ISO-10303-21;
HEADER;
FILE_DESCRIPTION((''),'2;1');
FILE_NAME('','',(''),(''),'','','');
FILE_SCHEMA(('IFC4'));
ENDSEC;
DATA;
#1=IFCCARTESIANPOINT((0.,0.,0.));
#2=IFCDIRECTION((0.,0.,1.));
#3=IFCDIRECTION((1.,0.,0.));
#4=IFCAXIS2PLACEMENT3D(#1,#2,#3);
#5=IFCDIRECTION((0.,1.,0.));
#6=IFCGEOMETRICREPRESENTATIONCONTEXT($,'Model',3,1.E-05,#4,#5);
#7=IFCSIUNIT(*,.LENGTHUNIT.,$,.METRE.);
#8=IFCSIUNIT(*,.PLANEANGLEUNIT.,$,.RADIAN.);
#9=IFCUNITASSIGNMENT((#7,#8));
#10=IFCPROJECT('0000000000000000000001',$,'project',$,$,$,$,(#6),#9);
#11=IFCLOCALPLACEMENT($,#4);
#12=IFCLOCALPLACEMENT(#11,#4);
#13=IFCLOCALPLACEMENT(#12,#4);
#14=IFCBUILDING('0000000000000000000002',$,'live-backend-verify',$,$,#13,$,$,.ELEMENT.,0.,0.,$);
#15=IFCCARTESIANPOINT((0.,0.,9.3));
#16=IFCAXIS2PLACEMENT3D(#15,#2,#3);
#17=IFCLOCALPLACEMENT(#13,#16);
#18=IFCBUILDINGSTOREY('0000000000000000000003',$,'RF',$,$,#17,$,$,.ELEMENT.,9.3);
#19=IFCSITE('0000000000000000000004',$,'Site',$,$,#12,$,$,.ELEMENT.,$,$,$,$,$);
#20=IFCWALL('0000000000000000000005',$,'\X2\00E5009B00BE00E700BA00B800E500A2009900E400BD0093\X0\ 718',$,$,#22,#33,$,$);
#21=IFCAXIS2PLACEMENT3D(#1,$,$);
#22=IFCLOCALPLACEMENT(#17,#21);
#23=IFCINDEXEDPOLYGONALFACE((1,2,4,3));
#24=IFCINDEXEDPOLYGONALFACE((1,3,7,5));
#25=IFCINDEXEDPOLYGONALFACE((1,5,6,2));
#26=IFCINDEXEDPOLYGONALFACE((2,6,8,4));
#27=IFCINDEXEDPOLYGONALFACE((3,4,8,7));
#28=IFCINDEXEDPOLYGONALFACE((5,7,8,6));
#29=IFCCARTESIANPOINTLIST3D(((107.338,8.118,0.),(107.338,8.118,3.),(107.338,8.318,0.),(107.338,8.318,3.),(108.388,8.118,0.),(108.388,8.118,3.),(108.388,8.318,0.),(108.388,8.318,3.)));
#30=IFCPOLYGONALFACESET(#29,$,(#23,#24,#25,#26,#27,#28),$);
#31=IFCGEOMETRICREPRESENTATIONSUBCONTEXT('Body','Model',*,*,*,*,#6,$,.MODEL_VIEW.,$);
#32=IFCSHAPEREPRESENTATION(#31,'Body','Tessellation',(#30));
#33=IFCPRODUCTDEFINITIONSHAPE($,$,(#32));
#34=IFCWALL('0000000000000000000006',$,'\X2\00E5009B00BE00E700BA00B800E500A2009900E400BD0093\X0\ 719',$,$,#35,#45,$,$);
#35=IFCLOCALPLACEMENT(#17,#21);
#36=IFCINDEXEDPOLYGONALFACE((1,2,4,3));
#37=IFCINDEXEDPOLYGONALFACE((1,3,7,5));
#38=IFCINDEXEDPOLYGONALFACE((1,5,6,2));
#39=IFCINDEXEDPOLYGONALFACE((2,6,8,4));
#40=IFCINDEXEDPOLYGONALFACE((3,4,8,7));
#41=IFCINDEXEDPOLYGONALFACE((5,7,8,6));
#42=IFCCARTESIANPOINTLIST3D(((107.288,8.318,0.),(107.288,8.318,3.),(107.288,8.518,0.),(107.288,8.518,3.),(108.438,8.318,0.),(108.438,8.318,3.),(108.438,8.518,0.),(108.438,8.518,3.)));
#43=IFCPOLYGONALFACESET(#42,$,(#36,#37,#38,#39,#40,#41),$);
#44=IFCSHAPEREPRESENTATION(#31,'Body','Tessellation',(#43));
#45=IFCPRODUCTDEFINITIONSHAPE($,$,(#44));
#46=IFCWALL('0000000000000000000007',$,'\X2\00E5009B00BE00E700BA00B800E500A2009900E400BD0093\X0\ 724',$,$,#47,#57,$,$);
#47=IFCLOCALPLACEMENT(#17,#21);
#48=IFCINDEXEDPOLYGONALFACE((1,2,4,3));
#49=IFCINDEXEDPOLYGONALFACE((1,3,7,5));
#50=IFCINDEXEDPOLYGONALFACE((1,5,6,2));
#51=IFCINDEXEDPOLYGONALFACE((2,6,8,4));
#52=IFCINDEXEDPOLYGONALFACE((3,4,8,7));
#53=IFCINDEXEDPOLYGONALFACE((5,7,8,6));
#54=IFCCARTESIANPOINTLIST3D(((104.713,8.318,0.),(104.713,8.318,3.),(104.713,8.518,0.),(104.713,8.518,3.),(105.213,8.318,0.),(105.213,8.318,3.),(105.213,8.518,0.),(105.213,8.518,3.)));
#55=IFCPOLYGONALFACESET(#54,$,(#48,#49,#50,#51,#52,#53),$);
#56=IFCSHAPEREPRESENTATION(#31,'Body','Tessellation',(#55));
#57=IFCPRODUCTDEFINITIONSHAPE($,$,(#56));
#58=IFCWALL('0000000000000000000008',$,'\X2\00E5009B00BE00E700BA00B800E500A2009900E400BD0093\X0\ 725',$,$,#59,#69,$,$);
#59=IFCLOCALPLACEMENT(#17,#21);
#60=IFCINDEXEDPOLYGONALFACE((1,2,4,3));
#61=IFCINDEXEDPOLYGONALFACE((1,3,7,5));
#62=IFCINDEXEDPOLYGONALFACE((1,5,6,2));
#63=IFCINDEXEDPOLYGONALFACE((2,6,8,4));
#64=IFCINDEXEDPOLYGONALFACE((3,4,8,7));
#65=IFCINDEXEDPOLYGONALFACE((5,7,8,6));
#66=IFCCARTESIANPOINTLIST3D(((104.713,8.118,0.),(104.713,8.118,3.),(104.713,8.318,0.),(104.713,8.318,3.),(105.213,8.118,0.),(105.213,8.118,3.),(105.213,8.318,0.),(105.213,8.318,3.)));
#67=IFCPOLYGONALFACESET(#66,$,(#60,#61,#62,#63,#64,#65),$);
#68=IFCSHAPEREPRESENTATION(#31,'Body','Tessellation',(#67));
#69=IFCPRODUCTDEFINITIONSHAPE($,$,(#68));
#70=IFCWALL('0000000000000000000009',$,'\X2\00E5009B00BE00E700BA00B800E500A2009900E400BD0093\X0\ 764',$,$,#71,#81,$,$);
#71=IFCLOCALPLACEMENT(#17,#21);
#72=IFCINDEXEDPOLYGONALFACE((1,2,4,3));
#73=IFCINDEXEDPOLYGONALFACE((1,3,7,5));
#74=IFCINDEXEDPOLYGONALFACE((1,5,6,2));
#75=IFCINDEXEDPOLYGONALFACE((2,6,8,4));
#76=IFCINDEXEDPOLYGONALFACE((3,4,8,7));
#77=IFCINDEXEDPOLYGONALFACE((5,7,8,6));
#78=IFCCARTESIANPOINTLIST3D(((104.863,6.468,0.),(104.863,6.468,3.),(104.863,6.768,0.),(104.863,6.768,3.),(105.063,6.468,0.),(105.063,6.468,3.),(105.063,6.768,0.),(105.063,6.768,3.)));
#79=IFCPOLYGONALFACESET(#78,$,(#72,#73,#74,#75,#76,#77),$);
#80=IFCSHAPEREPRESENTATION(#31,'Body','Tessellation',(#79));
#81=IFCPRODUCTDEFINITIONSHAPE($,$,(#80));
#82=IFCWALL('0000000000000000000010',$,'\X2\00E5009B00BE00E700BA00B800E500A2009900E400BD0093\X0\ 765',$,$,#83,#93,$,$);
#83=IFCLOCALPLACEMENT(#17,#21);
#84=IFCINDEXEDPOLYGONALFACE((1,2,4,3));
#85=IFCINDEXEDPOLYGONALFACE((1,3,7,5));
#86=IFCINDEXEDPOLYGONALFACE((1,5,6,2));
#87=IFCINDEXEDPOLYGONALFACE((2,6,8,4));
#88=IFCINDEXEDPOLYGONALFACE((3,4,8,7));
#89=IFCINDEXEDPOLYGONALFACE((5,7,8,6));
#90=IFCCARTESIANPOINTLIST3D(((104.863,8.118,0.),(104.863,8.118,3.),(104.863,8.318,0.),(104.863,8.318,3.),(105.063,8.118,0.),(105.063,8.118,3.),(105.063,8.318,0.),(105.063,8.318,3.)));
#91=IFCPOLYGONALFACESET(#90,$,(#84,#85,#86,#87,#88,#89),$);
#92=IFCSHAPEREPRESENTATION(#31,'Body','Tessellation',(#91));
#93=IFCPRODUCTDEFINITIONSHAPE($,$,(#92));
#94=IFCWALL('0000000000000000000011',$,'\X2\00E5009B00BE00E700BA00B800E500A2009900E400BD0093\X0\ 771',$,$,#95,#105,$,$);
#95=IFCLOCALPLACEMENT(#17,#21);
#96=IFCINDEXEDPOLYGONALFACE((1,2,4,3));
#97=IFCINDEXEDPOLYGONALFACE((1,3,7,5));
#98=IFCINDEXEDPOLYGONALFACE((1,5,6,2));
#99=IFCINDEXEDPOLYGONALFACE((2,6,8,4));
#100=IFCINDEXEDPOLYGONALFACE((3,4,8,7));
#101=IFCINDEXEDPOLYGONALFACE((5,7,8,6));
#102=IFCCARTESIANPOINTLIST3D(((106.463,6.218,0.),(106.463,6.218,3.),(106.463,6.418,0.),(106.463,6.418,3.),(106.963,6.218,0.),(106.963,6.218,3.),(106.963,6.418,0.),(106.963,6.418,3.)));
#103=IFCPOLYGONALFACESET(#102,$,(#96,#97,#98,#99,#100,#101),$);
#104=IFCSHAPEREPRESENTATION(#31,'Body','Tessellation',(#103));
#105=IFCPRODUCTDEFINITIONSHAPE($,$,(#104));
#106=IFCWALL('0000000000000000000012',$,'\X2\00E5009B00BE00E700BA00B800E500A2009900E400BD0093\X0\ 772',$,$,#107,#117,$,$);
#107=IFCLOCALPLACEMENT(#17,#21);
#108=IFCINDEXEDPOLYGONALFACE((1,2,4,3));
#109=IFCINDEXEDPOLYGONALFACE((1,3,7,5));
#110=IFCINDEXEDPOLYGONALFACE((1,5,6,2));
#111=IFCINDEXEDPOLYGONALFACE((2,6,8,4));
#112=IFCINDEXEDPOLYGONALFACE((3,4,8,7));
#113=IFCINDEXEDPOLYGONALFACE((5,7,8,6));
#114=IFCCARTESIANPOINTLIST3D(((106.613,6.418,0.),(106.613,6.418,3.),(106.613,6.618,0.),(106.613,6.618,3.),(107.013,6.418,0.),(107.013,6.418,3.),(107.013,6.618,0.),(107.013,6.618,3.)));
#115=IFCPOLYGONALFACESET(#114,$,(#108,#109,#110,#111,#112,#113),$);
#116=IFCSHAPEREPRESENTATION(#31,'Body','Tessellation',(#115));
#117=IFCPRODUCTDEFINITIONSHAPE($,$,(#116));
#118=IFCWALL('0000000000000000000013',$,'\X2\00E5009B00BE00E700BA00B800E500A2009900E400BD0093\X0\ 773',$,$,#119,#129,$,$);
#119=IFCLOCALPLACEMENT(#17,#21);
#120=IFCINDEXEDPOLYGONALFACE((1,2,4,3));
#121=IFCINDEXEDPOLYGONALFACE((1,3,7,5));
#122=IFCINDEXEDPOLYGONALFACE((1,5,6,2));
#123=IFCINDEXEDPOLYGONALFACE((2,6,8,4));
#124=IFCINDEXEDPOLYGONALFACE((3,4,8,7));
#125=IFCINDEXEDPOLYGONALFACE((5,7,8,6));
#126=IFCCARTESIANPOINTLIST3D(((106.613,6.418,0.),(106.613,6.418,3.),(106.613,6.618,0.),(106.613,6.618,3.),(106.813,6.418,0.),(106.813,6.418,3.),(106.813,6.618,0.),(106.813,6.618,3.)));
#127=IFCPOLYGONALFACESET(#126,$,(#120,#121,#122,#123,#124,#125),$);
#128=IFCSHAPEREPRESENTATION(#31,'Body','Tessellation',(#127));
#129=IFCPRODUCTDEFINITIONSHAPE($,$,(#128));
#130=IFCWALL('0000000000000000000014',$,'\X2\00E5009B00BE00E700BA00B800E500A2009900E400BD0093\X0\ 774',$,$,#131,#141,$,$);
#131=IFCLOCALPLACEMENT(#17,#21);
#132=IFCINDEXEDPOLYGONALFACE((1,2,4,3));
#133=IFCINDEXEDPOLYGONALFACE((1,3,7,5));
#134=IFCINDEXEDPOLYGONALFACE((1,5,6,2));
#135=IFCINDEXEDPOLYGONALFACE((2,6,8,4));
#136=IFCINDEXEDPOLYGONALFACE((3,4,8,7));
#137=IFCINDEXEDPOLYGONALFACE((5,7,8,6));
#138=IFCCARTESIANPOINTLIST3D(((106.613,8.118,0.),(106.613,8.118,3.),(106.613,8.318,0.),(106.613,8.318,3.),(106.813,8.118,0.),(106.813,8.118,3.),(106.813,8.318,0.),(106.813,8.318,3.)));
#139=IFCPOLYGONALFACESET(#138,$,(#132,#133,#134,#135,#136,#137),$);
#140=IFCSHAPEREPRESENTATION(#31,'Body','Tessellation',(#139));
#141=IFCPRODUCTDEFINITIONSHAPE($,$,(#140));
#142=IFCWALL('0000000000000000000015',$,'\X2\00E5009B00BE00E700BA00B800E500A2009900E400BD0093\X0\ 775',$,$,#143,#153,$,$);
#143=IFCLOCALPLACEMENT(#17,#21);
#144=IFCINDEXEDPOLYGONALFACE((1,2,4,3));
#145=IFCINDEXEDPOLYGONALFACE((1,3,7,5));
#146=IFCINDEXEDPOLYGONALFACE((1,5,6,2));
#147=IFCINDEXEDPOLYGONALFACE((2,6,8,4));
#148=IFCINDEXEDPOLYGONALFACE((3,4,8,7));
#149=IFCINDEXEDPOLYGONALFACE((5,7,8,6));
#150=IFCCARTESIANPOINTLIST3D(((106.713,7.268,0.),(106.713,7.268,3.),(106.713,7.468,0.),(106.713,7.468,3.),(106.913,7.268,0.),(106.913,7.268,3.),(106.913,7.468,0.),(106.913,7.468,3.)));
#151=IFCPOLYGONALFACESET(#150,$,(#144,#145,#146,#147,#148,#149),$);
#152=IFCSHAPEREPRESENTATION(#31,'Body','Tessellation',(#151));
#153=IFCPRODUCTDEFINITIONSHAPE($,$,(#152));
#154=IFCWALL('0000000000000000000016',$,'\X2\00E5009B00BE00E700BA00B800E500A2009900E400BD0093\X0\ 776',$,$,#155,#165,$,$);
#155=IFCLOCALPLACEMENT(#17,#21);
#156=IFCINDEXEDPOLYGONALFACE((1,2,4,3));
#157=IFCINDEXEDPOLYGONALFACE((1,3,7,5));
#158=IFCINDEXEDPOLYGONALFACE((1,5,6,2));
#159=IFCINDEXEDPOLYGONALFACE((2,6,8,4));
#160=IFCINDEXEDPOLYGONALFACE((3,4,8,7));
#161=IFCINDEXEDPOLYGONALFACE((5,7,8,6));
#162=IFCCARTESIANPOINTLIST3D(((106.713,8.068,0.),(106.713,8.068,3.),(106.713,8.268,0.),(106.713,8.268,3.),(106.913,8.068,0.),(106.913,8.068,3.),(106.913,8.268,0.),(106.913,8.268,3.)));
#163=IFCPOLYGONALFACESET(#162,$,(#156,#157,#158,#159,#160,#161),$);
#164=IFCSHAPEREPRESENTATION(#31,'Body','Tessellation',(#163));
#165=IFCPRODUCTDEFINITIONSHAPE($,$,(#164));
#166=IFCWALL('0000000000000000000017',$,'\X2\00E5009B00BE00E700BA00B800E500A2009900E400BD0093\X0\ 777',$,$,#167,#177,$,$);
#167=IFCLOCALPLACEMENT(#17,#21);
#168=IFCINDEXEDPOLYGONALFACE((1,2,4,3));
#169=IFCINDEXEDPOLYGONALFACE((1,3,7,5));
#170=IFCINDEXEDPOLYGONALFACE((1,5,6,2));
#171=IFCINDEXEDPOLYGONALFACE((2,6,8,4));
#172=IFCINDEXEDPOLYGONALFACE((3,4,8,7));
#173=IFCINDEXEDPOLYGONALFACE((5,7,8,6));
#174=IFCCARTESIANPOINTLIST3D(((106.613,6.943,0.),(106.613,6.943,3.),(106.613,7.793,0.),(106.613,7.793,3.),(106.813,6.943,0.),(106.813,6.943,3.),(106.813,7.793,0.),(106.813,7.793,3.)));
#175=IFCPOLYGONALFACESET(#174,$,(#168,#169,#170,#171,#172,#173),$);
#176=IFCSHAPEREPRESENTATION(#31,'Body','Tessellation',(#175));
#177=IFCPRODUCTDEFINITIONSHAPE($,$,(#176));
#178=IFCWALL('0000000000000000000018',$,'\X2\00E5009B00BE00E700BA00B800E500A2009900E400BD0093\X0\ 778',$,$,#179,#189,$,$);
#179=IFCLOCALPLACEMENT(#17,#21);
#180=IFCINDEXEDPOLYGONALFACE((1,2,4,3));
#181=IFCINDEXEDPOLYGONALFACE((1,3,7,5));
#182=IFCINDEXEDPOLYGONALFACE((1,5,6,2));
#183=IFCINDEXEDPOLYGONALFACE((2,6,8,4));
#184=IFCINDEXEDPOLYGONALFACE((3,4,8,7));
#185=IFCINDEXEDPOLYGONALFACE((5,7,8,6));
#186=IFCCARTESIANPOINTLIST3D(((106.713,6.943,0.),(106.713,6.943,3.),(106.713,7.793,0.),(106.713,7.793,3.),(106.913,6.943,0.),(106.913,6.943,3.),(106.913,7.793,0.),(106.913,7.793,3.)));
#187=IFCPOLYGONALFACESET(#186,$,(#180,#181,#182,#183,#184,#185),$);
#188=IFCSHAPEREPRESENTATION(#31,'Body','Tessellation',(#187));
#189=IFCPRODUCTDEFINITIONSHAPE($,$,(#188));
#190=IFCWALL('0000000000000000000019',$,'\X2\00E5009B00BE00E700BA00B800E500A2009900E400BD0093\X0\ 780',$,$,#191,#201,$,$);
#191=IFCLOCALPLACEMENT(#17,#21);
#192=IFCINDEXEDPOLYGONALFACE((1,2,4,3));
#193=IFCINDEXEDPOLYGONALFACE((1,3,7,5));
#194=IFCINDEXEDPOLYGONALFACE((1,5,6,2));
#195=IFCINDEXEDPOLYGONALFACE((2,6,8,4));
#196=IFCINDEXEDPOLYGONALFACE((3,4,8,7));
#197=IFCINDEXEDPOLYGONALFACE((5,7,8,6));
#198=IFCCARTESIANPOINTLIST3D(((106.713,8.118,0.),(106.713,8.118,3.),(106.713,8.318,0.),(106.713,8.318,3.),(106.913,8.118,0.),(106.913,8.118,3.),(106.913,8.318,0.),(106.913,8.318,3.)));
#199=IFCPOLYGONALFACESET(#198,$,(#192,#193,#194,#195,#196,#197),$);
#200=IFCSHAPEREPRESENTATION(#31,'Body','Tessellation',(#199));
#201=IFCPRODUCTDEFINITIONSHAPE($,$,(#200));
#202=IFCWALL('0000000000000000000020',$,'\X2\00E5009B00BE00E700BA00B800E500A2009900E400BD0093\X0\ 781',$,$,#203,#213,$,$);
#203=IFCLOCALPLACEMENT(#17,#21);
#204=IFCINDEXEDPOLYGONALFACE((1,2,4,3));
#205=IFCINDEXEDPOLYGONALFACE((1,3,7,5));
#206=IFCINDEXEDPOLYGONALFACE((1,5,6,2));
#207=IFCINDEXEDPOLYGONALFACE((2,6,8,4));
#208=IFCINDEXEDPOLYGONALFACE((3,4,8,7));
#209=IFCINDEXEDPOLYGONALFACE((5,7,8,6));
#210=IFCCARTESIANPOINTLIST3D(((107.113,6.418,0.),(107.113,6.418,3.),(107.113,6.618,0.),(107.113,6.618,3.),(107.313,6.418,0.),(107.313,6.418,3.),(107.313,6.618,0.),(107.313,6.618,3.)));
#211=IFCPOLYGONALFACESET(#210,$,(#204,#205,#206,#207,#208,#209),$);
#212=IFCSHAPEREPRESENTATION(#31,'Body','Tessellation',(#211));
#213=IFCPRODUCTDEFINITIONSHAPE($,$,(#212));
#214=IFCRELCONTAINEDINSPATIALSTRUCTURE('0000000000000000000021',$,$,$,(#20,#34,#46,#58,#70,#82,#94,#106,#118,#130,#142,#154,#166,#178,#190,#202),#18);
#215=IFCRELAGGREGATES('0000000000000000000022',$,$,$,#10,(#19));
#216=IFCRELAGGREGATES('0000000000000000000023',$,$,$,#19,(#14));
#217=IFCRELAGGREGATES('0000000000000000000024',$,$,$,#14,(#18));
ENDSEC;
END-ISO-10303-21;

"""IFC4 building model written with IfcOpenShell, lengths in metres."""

from ifc_helpers import new_model, si_unit, direction, frame, frame_2d, origin_with_axes, place, context, subcontext, project, spatial, rectangle, extrude, element, save


model = new_model("IFC4")

# Units and contexts
model_context = context("Model", 3, precision=1e-05, world=origin_with_axes(), true_north=direction((0.0, 1.0, 0.0)))
body_context = subcontext(model_context, "Body", "Model", "MODEL_VIEW")
ifc_project = project(units=[si_unit("LENGTHUNIT", "METRE"), si_unit("PLANEANGLEUNIT", "RADIAN")], contexts=[model_context])

# Site, building, storey
placement = place(None, origin_with_axes())
site_placement = place(placement, origin_with_axes())
site = spatial("IfcSite", under=ifc_project, at=site_placement, Name="Site", CompositionType="ELEMENT")
building_placement = place(site_placement, origin_with_axes())
building = spatial("IfcBuilding", under=site, at=building_placement, Name="live-backend-verify", CompositionType="ELEMENT", ElevationOfRefHeight=0.0, ElevationOfTerrain=0.0)
storey_placement = place(building_placement, frame((0.0, 0.0, 9.3), z_axis=(0.0, 0.0, 1.0), x_axis=(1.0, 0.0, 0.0)))
storey = spatial("IfcBuildingStorey", under=building, at=storey_placement, Name="RF", CompositionType="ELEMENT", Elevation=9.3)

# Walls
wall_1_placement = place(storey_placement, frame((107.863, 8.218, 0.0), z_axis=(0.0, 0.0, 1.0), x_axis=(-1.0, 0.0, 0.0)))
element("IfcWall", 1, at=wall_1_placement, inside=storey, Name="å\u009b¾çº¸å¢\u0099ä½\u0093 718", context=body_context, shape_type="SweptSolid", body=[
    extrude(rectangle(XDim=1.05, YDim=0.2, at=frame_2d((0.0, 0.0), x_axis=(1.0, 0.0, 0.0))), frame((0.0, 0.0, 0.0), z_axis=(0.0, 0.0, 1.0)), (0.0, 0.0, 1.0), 3.0),
])
wall_2_placement = place(storey_placement, frame((107.863, 8.418, 0.0), z_axis=(0.0, 0.0, 1.0), x_axis=(-1.0, 0.0, 0.0)))
element("IfcWall", 2, at=wall_2_placement, inside=storey, Name="å\u009b¾çº¸å¢\u0099ä½\u0093 719", context=body_context, shape_type="SweptSolid", body=[
    extrude(rectangle(XDim=1.15, YDim=0.2, at=frame_2d((0.0, 0.0), x_axis=(1.0, 0.0, 0.0))), frame((0.0, 0.0, 0.0), z_axis=(0.0, 0.0, 1.0)), (0.0, 0.0, 1.0), 3.0),
])
for number, where, z_axis, x_axis, name in (
    (3, (104.963, 8.418, 0.0), (0.0, 0.0, 1.0), (-1.0, 0.0, 0.0), "å\u009b¾çº¸å¢\u0099ä½\u0093 724"),
    (4, (104.963, 8.218, 0.0), (0.0, 0.0, 1.0), (-1.0, 0.0, 0.0), "å\u009b¾çº¸å¢\u0099ä½\u0093 725"),
):
    element("IfcWall", number, at=place(storey_placement, frame(where, z_axis=z_axis, x_axis=x_axis)), inside=storey, Name=name, context=body_context, shape_type="SweptSolid", body=[
        extrude(rectangle(XDim=0.5, YDim=0.2, at=frame_2d((0.0, 0.0), x_axis=(1.0, 0.0, 0.0))), frame((0.0, 0.0, 0.0), z_axis=(0.0, 0.0, 1.0)), (0.0, 0.0, 1.0), 3.0),
    ])
wall_3_placement = place(storey_placement, frame((104.963, 6.618, 0.0), z_axis=(0.0, 0.0, 1.0), x_axis=(0.0, -1.0, 0.0)))
element("IfcWall", 5, at=wall_3_placement, inside=storey, Name="å\u009b¾çº¸å¢\u0099ä½\u0093 764", context=body_context, shape_type="SweptSolid", body=[
    extrude(rectangle(XDim=0.3, YDim=0.2, at=frame_2d((0.0, 0.0), x_axis=(1.0, 0.0, 0.0))), frame((0.0, 0.0, 0.0), z_axis=(0.0, 0.0, 1.0)), (0.0, 0.0, 1.0), 3.0),
])
wall_4_placement = place(storey_placement, frame((104.963, 8.218, 0.0), z_axis=(0.0, 0.0, 1.0), x_axis=(0.0, 1.0, 0.0)))
element("IfcWall", 6, at=wall_4_placement, inside=storey, Name="å\u009b¾çº¸å¢\u0099ä½\u0093 765", context=body_context, shape_type="SweptSolid", body=[
    extrude(rectangle(XDim=0.2, YDim=0.2, at=frame_2d((0.0, 0.0), x_axis=(1.0, 0.0, 0.0))), frame((0.0, 0.0, 0.0), z_axis=(0.0, 0.0, 1.0)), (0.0, 0.0, 1.0), 3.0),
])
wall_5_placement = place(storey_placement, frame((106.713, 6.318, 0.0), z_axis=(0.0, 0.0, 1.0), x_axis=(1.0, 0.0, 0.0)))
element("IfcWall", 7, at=wall_5_placement, inside=storey, Name="å\u009b¾çº¸å¢\u0099ä½\u0093 771", context=body_context, shape_type="SweptSolid", body=[
    extrude(rectangle(XDim=0.5, YDim=0.2, at=frame_2d((0.0, 0.0), x_axis=(1.0, 0.0, 0.0))), frame((0.0, 0.0, 0.0), z_axis=(0.0, 0.0, 1.0)), (0.0, 0.0, 1.0), 3.0),
])
wall_6_placement = place(storey_placement, frame((106.813, 6.518, 0.0), z_axis=(0.0, 0.0, 1.0), x_axis=(1.0, 0.0, 0.0)))
element("IfcWall", 8, at=wall_6_placement, inside=storey, Name="å\u009b¾çº¸å¢\u0099ä½\u0093 772", context=body_context, shape_type="SweptSolid", body=[
    extrude(rectangle(XDim=0.4, YDim=0.2, at=frame_2d((0.0, 0.0), x_axis=(1.0, 0.0, 0.0))), frame((0.0, 0.0, 0.0), z_axis=(0.0, 0.0, 1.0)), (0.0, 0.0, 1.0), 3.0),
])
for number, where, z_axis, x_axis, name in (
    (9, (106.713, 6.518, 0.0), (0.0, 0.0, 1.0), (0.0, -1.0, 0.0), "å\u009b¾çº¸å¢\u0099ä½\u0093 773"),
    (10, (106.713, 8.218, 0.0), (0.0, 0.0, 1.0), (0.0, 1.0, 0.0), "å\u009b¾çº¸å¢\u0099ä½\u0093 774"),
    (11, (106.813, 7.368, 0.0), (0.0, 0.0, 1.0), (-1.0, 0.0, 0.0), "å\u009b¾çº¸å¢\u0099ä½\u0093 775"),
    (12, (106.813, 8.168, 0.0), (0.0, 0.0, 1.0), (-1.0, 0.0, 0.0), "å\u009b¾çº¸å¢\u0099ä½\u0093 776"),
):
    element("IfcWall", number, at=place(storey_placement, frame(where, z_axis=z_axis, x_axis=x_axis)), inside=storey, Name=name, context=body_context, shape_type="SweptSolid", body=[
        extrude(rectangle(XDim=0.2, YDim=0.2, at=frame_2d((0.0, 0.0), x_axis=(1.0, 0.0, 0.0))), frame((0.0, 0.0, 0.0), z_axis=(0.0, 0.0, 1.0)), (0.0, 0.0, 1.0), 3.0),
    ])
for number, where, z_axis, x_axis, name in (
    (13, (106.713, 7.368, 0.0), (0.0, 0.0, 1.0), (0.0, -1.0, 0.0), "å\u009b¾çº¸å¢\u0099ä½\u0093 777"),
    (14, (106.813, 7.368, 0.0), (0.0, 0.0, 1.0), (0.0, -1.0, 0.0), "å\u009b¾çº¸å¢\u0099ä½\u0093 778"),
):
    element("IfcWall", number, at=place(storey_placement, frame(where, z_axis=z_axis, x_axis=x_axis)), inside=storey, Name=name, context=body_context, shape_type="SweptSolid", body=[
        extrude(rectangle(XDim=0.85, YDim=0.2, at=frame_2d((0.0, 0.0), x_axis=(1.0, 0.0, 0.0))), frame((0.0, 0.0, 0.0), z_axis=(0.0, 0.0, 1.0)), (0.0, 0.0, 1.0), 3.0),
    ])
for number, where, z_axis, x_axis, name in (
    (15, (106.813, 8.218, 0.0), (0.0, 0.0, 1.0), (0.0, -1.0, 0.0), "å\u009b¾çº¸å¢\u0099ä½\u0093 780"),
    (16, (107.213, 6.518, 0.0), (0.0, 0.0, 1.0), (0.0, -1.0, 0.0), "å\u009b¾çº¸å¢\u0099ä½\u0093 781"),
):
    element("IfcWall", number, at=place(storey_placement, frame(where, z_axis=z_axis, x_axis=x_axis)), inside=storey, Name=name, context=body_context, shape_type="SweptSolid", body=[
        extrude(rectangle(XDim=0.2, YDim=0.2, at=frame_2d((0.0, 0.0), x_axis=(1.0, 0.0, 0.0))), frame((0.0, 0.0, 0.0), z_axis=(0.0, 0.0, 1.0)), (0.0, 0.0, 1.0), 3.0),
    ])

save(model, "model.ifc")
